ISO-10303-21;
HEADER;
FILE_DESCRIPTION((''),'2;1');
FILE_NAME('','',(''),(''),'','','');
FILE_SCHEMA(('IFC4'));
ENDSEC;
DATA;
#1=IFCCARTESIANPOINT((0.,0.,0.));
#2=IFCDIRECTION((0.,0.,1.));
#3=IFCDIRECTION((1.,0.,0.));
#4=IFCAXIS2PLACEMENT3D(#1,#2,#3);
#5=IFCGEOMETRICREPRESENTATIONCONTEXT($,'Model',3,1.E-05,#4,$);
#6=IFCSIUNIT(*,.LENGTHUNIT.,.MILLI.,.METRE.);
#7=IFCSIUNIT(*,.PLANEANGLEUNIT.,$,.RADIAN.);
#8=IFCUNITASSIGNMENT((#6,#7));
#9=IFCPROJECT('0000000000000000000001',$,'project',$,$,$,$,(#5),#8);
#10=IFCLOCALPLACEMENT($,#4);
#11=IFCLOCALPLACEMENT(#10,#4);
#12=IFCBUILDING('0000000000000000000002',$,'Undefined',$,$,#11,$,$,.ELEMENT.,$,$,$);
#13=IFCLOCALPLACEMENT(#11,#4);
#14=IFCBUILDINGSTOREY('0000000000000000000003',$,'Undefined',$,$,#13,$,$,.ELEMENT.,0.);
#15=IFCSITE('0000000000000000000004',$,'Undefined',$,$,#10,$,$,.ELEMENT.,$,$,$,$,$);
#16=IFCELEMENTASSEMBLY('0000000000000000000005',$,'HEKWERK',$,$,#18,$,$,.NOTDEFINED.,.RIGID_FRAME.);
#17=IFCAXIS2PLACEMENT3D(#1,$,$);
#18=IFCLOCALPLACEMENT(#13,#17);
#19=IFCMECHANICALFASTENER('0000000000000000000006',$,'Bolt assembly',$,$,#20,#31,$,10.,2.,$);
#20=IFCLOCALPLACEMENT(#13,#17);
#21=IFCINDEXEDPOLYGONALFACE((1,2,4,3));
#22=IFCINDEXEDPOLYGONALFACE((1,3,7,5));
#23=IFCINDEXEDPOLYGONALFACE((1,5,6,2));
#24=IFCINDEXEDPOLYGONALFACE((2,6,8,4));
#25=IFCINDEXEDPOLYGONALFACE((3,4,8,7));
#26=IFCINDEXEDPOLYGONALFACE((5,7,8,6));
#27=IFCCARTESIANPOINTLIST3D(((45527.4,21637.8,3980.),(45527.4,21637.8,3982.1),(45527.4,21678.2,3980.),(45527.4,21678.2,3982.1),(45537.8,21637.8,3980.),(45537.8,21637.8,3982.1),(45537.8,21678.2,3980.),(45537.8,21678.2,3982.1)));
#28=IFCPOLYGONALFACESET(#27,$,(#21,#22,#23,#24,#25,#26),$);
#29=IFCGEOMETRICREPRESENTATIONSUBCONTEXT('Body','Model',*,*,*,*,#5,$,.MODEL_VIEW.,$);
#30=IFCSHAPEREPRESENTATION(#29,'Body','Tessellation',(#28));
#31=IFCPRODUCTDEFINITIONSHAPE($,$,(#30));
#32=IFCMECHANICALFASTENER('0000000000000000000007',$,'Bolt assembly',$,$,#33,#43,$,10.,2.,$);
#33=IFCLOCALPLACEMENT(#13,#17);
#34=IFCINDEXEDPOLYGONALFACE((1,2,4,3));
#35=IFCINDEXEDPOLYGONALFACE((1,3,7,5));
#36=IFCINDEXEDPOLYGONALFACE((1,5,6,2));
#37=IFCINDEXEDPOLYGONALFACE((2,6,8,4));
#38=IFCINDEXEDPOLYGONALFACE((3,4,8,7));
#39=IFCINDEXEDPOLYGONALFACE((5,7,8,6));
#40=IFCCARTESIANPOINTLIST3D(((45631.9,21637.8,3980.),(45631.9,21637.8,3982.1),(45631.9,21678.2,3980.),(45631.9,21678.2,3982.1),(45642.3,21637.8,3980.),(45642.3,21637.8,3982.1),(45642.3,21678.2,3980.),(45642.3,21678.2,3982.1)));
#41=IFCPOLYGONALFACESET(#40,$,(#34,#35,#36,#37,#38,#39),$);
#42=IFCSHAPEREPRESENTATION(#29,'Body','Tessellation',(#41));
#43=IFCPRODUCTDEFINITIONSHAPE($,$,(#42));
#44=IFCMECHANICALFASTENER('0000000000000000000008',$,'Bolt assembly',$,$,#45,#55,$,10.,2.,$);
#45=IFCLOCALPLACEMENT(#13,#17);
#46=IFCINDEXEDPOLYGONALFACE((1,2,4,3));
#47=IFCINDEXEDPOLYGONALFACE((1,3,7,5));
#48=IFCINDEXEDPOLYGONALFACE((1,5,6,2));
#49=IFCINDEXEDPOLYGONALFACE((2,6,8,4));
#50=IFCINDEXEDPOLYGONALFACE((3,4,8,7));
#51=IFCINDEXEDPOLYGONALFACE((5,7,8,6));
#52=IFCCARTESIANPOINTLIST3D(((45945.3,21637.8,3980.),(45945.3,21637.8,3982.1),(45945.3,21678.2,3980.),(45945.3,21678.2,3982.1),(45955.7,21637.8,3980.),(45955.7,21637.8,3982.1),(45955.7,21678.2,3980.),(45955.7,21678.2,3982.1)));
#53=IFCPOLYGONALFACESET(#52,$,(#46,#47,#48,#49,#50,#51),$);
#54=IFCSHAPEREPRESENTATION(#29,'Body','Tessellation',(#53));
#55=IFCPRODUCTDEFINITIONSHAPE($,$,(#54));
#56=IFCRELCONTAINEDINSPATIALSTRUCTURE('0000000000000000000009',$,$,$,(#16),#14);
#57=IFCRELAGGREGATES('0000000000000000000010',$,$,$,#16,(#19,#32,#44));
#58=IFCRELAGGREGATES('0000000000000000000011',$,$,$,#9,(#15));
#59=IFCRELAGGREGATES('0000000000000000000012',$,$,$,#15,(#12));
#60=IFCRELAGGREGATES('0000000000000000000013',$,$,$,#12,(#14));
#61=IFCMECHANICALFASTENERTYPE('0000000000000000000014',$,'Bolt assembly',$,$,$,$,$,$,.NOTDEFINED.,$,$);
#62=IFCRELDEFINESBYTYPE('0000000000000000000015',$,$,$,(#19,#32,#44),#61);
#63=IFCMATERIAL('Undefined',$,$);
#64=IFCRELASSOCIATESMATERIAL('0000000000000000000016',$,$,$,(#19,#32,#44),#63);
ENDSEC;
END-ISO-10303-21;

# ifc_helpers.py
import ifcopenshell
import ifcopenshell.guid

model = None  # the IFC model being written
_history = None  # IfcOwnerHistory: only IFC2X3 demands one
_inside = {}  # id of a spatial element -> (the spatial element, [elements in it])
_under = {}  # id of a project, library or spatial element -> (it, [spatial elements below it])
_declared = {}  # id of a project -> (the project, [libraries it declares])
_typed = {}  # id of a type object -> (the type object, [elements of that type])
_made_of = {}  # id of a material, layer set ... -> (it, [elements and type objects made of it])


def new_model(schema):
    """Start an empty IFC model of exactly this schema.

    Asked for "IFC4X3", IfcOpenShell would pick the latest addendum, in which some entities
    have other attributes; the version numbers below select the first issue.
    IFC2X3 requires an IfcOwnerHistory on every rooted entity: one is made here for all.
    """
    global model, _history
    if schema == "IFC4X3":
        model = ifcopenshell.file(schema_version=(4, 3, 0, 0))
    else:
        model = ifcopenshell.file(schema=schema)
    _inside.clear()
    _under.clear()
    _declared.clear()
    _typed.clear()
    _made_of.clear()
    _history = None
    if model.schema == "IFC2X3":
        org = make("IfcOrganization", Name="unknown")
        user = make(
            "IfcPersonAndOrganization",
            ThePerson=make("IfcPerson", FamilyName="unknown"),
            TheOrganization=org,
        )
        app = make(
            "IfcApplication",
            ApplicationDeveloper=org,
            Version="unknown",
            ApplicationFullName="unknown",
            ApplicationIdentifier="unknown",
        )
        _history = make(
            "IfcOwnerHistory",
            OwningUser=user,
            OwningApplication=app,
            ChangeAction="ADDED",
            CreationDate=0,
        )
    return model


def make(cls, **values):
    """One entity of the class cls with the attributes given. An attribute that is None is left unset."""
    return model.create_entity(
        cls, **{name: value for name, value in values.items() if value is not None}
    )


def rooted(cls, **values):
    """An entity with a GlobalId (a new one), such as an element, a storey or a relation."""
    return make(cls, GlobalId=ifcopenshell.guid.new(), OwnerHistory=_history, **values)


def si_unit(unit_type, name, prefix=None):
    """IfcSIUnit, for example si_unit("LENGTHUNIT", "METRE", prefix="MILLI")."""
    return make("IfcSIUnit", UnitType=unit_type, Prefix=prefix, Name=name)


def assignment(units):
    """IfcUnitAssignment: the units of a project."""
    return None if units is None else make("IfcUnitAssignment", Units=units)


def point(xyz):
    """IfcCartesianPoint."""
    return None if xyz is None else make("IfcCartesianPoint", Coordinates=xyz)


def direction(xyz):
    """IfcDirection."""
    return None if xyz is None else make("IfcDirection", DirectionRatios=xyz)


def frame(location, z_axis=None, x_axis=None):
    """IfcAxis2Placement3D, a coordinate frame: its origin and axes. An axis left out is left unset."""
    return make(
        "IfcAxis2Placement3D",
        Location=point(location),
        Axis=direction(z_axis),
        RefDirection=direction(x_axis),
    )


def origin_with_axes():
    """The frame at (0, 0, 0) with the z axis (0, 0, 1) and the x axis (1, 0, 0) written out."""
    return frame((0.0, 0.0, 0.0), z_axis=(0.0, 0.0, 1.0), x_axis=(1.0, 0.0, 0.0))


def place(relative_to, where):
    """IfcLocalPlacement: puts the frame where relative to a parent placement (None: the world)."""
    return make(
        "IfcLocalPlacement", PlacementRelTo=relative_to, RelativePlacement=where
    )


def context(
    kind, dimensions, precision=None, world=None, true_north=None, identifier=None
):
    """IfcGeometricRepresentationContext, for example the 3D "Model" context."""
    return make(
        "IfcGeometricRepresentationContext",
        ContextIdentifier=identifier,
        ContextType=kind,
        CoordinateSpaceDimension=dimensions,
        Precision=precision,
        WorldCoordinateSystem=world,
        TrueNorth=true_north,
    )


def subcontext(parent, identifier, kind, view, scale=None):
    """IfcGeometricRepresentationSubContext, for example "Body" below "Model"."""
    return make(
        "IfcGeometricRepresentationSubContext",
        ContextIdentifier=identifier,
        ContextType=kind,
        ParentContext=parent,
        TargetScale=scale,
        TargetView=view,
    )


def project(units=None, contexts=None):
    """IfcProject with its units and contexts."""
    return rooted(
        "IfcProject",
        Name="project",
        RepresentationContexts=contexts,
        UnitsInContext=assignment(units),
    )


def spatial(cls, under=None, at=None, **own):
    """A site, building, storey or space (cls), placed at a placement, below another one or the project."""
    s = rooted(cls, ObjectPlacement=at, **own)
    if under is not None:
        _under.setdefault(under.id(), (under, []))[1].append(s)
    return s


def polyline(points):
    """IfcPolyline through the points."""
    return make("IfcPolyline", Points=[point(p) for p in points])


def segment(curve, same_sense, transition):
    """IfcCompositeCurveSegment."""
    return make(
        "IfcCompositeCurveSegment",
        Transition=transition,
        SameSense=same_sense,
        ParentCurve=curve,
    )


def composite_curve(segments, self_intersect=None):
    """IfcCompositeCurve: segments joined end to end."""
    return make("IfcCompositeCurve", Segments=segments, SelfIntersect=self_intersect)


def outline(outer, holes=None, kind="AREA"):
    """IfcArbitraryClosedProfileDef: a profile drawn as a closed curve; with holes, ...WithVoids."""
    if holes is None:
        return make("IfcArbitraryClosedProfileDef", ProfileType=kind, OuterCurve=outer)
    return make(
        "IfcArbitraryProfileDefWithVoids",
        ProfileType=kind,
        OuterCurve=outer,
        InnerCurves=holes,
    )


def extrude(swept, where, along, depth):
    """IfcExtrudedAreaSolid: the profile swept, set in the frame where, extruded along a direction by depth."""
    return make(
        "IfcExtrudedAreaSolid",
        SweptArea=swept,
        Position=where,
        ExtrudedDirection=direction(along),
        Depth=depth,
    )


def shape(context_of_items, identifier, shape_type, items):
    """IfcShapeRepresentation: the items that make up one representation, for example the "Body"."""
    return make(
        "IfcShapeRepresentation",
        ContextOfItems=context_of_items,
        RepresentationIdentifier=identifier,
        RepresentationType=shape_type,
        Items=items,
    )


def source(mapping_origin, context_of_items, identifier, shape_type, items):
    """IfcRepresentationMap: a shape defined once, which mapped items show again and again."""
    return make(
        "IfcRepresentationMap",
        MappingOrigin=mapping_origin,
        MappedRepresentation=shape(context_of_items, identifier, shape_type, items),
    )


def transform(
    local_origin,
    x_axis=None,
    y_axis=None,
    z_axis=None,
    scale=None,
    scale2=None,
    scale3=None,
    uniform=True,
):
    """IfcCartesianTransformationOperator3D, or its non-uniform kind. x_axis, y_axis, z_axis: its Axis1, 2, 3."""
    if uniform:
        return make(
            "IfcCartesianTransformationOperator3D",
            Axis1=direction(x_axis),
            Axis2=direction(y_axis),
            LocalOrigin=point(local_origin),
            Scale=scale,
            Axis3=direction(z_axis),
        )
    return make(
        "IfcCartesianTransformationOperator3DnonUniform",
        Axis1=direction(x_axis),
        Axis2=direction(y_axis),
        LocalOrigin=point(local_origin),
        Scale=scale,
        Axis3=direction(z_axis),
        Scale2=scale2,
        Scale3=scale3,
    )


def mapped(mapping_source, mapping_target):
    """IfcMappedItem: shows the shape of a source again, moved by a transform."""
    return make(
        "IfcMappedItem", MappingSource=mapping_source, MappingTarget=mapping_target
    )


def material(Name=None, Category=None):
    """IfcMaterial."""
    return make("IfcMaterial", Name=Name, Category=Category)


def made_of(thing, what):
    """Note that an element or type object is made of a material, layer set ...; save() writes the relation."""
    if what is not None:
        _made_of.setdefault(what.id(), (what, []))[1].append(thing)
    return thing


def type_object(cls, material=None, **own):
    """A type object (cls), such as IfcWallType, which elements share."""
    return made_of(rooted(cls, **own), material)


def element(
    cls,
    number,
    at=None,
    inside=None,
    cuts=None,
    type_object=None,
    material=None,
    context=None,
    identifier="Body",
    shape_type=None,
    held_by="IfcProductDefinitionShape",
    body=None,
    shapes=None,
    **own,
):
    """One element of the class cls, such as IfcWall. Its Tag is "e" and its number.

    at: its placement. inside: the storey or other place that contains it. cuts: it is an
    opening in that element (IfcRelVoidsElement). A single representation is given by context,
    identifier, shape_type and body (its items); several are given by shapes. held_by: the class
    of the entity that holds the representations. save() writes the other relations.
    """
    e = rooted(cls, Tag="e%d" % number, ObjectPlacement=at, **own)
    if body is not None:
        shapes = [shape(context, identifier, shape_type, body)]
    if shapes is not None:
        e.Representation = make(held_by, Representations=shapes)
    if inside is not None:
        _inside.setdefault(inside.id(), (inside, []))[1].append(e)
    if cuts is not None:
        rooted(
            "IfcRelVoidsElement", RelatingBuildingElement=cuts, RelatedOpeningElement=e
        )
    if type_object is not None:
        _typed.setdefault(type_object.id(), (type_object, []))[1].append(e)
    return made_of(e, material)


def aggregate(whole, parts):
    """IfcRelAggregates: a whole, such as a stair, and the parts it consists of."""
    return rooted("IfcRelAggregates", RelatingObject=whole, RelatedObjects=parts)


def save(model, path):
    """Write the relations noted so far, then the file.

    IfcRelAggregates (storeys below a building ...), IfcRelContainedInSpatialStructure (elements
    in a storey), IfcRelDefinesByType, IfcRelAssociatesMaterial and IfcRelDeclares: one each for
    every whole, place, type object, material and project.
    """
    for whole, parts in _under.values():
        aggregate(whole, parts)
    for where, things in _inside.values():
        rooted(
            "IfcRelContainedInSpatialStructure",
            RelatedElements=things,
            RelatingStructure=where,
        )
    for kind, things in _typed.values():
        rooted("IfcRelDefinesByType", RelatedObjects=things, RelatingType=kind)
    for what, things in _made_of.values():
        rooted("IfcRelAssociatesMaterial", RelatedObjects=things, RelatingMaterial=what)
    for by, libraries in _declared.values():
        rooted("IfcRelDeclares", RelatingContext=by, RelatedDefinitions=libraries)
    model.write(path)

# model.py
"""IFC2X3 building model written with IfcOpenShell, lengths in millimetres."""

from ifc_helpers import new_model, si_unit, frame, origin_with_axes, place, context, subcontext, project, spatial, polyline, segment, composite_curve, outline, extrude, source, transform, mapped, material, type_object, element, aggregate, save


model = new_model("IFC2X3")

# Units and contexts
model_context = context("Model", 3, precision=1e-05, world=origin_with_axes())
body_context = subcontext(model_context, "Body", "Model", "MODEL_VIEW")
ifc_project = project(units=[si_unit("LENGTHUNIT", "METRE", prefix="MILLI"), si_unit("PLANEANGLEUNIT", "RADIAN")], contexts=[model_context])

# Site, building, storey
site_placement = place(None, origin_with_axes())
site = spatial("IfcSite", under=ifc_project, at=site_placement, Name="Undefined", CompositionType="ELEMENT")
building_placement = place(site_placement, origin_with_axes())
building = spatial("IfcBuilding", under=site, at=building_placement, Name="Undefined", CompositionType="ELEMENT")
storey_placement = place(building_placement, origin_with_axes())
storey = spatial("IfcBuildingStorey", under=building, at=storey_placement, Name="Undefined", CompositionType="ELEMENT", Elevation=0.0)

# Element assembly
assembly_1_placement = place(storey_placement, origin_with_axes())
assembly_1 = element("IfcElementAssembly", 1, at=assembly_1_placement, inside=storey, Name="HEKWERK", AssemblyPlace="NOTDEFINED", PredefinedType="RIGID_FRAME")

# Mechanical fasteners
ifc_material_1 = material(Name="Undefined")
mechanical_fastener_type = type_object("IfcMechanicalFastenerType", Name="Bolt assembly")
shared_shape_1 = source(origin_with_axes(), body_context, "Body", "SweptSolid", [
    extrude(outline(composite_curve([segment(polyline([(-20.2, 5.2), (20.2, 5.2)]), True, "CONTINUOUS"), segment(polyline([(20.2, 5.2), (20.2, -5.2)]), True, "CONTINUOUS"), segment(polyline([(20.2, -5.2), (-20.2, -5.2)]), True, "CONTINUOUS"), segment(polyline([(-20.2, -5.2), (-20.2, 5.2)]), True, "CONTINUOUS")], self_intersect=False)), frame((0.0, -1.0, 0.0), z_axis=(0.0, 1.0, 0.0), x_axis=(1.0, 0.0, 0.0)), (0.0, 0.0, 1.0), 2.1),
])
mechanical_fastener_1_placement = place(assembly_1_placement, frame((45532.6, 21658.0, 3981.0), z_axis=(1.0, 0.0, 0.0), x_axis=(0.0, 1.0, 0.0)))
mechanical_fastener_1 = element("IfcMechanicalFastener", 2, at=mechanical_fastener_1_placement, type_object=mechanical_fastener_type, material=ifc_material_1, Name="Bolt assembly", NominalDiameter=10.0, NominalLength=2.0, context=body_context, shape_type="MappedRepresentation", body=[
    mapped(shared_shape_1, transform((0.0, 0.0, 0.0))),
])
shared_shape_2 = source(origin_with_axes(), body_context, "Body", "SweptSolid", [
    extrude(outline(composite_curve([segment(polyline([(-20.2, 5.2), (20.2, 5.2)]), True, "CONTINUOUS"), segment(polyline([(20.2, 5.2), (20.2, -5.2)]), True, "CONTINUOUS"), segment(polyline([(20.2, -5.2), (-20.2, -5.2)]), True, "CONTINUOUS"), segment(polyline([(-20.2, -5.2), (-20.2, 5.2)]), True, "CONTINUOUS")], self_intersect=False)), frame((0.0, -1.0, 0.0), z_axis=(0.0, 1.0, 0.0), x_axis=(1.0, 0.0, 0.0)), (0.0, 0.0, 1.0), 2.1),
])
mechanical_fastener_2_placement = place(assembly_1_placement, frame((45637.1, 21658.0, 3981.0), z_axis=(1.0, 0.0, 0.0), x_axis=(0.0, 1.0, 0.0)))
mechanical_fastener_2 = element("IfcMechanicalFastener", 3, at=mechanical_fastener_2_placement, type_object=mechanical_fastener_type, material=ifc_material_1, Name="Bolt assembly", NominalDiameter=10.0, NominalLength=2.0, context=body_context, shape_type="MappedRepresentation", body=[
    mapped(shared_shape_2, transform((0.0, 0.0, 0.0))),
])
shared_shape_3 = source(origin_with_axes(), body_context, "Body", "SweptSolid", [
    extrude(outline(composite_curve([segment(polyline([(-20.2, 5.2), (20.2, 5.2)]), True, "CONTINUOUS"), segment(polyline([(20.2, 5.2), (20.2, -5.2)]), True, "CONTINUOUS"), segment(polyline([(20.2, -5.2), (-20.2, -5.2)]), True, "CONTINUOUS"), segment(polyline([(-20.2, -5.2), (-20.2, 5.2)]), True, "CONTINUOUS")], self_intersect=False)), frame((0.0, -1.0, 0.0), z_axis=(0.0, 1.0, 0.0), x_axis=(1.0, 0.0, 0.0)), (0.0, 0.0, 1.0), 2.1),
])
mechanical_fastener_3_placement = place(assembly_1_placement, frame((45950.5, 21658.0, 3981.0), z_axis=(1.0, 0.0, 0.0), x_axis=(0.0, 1.0, 0.0)))
mechanical_fastener_3 = element("IfcMechanicalFastener", 4, at=mechanical_fastener_3_placement, type_object=mechanical_fastener_type, material=ifc_material_1, Name="Bolt assembly", NominalDiameter=10.0, NominalLength=2.0, context=body_context, shape_type="MappedRepresentation", body=[
    mapped(shared_shape_3, transform((0.0, 0.0, 0.0))),
])
aggregate(assembly_1, [mechanical_fastener_1, mechanical_fastener_2, mechanical_fastener_3])

save(model, "model.ifc")
